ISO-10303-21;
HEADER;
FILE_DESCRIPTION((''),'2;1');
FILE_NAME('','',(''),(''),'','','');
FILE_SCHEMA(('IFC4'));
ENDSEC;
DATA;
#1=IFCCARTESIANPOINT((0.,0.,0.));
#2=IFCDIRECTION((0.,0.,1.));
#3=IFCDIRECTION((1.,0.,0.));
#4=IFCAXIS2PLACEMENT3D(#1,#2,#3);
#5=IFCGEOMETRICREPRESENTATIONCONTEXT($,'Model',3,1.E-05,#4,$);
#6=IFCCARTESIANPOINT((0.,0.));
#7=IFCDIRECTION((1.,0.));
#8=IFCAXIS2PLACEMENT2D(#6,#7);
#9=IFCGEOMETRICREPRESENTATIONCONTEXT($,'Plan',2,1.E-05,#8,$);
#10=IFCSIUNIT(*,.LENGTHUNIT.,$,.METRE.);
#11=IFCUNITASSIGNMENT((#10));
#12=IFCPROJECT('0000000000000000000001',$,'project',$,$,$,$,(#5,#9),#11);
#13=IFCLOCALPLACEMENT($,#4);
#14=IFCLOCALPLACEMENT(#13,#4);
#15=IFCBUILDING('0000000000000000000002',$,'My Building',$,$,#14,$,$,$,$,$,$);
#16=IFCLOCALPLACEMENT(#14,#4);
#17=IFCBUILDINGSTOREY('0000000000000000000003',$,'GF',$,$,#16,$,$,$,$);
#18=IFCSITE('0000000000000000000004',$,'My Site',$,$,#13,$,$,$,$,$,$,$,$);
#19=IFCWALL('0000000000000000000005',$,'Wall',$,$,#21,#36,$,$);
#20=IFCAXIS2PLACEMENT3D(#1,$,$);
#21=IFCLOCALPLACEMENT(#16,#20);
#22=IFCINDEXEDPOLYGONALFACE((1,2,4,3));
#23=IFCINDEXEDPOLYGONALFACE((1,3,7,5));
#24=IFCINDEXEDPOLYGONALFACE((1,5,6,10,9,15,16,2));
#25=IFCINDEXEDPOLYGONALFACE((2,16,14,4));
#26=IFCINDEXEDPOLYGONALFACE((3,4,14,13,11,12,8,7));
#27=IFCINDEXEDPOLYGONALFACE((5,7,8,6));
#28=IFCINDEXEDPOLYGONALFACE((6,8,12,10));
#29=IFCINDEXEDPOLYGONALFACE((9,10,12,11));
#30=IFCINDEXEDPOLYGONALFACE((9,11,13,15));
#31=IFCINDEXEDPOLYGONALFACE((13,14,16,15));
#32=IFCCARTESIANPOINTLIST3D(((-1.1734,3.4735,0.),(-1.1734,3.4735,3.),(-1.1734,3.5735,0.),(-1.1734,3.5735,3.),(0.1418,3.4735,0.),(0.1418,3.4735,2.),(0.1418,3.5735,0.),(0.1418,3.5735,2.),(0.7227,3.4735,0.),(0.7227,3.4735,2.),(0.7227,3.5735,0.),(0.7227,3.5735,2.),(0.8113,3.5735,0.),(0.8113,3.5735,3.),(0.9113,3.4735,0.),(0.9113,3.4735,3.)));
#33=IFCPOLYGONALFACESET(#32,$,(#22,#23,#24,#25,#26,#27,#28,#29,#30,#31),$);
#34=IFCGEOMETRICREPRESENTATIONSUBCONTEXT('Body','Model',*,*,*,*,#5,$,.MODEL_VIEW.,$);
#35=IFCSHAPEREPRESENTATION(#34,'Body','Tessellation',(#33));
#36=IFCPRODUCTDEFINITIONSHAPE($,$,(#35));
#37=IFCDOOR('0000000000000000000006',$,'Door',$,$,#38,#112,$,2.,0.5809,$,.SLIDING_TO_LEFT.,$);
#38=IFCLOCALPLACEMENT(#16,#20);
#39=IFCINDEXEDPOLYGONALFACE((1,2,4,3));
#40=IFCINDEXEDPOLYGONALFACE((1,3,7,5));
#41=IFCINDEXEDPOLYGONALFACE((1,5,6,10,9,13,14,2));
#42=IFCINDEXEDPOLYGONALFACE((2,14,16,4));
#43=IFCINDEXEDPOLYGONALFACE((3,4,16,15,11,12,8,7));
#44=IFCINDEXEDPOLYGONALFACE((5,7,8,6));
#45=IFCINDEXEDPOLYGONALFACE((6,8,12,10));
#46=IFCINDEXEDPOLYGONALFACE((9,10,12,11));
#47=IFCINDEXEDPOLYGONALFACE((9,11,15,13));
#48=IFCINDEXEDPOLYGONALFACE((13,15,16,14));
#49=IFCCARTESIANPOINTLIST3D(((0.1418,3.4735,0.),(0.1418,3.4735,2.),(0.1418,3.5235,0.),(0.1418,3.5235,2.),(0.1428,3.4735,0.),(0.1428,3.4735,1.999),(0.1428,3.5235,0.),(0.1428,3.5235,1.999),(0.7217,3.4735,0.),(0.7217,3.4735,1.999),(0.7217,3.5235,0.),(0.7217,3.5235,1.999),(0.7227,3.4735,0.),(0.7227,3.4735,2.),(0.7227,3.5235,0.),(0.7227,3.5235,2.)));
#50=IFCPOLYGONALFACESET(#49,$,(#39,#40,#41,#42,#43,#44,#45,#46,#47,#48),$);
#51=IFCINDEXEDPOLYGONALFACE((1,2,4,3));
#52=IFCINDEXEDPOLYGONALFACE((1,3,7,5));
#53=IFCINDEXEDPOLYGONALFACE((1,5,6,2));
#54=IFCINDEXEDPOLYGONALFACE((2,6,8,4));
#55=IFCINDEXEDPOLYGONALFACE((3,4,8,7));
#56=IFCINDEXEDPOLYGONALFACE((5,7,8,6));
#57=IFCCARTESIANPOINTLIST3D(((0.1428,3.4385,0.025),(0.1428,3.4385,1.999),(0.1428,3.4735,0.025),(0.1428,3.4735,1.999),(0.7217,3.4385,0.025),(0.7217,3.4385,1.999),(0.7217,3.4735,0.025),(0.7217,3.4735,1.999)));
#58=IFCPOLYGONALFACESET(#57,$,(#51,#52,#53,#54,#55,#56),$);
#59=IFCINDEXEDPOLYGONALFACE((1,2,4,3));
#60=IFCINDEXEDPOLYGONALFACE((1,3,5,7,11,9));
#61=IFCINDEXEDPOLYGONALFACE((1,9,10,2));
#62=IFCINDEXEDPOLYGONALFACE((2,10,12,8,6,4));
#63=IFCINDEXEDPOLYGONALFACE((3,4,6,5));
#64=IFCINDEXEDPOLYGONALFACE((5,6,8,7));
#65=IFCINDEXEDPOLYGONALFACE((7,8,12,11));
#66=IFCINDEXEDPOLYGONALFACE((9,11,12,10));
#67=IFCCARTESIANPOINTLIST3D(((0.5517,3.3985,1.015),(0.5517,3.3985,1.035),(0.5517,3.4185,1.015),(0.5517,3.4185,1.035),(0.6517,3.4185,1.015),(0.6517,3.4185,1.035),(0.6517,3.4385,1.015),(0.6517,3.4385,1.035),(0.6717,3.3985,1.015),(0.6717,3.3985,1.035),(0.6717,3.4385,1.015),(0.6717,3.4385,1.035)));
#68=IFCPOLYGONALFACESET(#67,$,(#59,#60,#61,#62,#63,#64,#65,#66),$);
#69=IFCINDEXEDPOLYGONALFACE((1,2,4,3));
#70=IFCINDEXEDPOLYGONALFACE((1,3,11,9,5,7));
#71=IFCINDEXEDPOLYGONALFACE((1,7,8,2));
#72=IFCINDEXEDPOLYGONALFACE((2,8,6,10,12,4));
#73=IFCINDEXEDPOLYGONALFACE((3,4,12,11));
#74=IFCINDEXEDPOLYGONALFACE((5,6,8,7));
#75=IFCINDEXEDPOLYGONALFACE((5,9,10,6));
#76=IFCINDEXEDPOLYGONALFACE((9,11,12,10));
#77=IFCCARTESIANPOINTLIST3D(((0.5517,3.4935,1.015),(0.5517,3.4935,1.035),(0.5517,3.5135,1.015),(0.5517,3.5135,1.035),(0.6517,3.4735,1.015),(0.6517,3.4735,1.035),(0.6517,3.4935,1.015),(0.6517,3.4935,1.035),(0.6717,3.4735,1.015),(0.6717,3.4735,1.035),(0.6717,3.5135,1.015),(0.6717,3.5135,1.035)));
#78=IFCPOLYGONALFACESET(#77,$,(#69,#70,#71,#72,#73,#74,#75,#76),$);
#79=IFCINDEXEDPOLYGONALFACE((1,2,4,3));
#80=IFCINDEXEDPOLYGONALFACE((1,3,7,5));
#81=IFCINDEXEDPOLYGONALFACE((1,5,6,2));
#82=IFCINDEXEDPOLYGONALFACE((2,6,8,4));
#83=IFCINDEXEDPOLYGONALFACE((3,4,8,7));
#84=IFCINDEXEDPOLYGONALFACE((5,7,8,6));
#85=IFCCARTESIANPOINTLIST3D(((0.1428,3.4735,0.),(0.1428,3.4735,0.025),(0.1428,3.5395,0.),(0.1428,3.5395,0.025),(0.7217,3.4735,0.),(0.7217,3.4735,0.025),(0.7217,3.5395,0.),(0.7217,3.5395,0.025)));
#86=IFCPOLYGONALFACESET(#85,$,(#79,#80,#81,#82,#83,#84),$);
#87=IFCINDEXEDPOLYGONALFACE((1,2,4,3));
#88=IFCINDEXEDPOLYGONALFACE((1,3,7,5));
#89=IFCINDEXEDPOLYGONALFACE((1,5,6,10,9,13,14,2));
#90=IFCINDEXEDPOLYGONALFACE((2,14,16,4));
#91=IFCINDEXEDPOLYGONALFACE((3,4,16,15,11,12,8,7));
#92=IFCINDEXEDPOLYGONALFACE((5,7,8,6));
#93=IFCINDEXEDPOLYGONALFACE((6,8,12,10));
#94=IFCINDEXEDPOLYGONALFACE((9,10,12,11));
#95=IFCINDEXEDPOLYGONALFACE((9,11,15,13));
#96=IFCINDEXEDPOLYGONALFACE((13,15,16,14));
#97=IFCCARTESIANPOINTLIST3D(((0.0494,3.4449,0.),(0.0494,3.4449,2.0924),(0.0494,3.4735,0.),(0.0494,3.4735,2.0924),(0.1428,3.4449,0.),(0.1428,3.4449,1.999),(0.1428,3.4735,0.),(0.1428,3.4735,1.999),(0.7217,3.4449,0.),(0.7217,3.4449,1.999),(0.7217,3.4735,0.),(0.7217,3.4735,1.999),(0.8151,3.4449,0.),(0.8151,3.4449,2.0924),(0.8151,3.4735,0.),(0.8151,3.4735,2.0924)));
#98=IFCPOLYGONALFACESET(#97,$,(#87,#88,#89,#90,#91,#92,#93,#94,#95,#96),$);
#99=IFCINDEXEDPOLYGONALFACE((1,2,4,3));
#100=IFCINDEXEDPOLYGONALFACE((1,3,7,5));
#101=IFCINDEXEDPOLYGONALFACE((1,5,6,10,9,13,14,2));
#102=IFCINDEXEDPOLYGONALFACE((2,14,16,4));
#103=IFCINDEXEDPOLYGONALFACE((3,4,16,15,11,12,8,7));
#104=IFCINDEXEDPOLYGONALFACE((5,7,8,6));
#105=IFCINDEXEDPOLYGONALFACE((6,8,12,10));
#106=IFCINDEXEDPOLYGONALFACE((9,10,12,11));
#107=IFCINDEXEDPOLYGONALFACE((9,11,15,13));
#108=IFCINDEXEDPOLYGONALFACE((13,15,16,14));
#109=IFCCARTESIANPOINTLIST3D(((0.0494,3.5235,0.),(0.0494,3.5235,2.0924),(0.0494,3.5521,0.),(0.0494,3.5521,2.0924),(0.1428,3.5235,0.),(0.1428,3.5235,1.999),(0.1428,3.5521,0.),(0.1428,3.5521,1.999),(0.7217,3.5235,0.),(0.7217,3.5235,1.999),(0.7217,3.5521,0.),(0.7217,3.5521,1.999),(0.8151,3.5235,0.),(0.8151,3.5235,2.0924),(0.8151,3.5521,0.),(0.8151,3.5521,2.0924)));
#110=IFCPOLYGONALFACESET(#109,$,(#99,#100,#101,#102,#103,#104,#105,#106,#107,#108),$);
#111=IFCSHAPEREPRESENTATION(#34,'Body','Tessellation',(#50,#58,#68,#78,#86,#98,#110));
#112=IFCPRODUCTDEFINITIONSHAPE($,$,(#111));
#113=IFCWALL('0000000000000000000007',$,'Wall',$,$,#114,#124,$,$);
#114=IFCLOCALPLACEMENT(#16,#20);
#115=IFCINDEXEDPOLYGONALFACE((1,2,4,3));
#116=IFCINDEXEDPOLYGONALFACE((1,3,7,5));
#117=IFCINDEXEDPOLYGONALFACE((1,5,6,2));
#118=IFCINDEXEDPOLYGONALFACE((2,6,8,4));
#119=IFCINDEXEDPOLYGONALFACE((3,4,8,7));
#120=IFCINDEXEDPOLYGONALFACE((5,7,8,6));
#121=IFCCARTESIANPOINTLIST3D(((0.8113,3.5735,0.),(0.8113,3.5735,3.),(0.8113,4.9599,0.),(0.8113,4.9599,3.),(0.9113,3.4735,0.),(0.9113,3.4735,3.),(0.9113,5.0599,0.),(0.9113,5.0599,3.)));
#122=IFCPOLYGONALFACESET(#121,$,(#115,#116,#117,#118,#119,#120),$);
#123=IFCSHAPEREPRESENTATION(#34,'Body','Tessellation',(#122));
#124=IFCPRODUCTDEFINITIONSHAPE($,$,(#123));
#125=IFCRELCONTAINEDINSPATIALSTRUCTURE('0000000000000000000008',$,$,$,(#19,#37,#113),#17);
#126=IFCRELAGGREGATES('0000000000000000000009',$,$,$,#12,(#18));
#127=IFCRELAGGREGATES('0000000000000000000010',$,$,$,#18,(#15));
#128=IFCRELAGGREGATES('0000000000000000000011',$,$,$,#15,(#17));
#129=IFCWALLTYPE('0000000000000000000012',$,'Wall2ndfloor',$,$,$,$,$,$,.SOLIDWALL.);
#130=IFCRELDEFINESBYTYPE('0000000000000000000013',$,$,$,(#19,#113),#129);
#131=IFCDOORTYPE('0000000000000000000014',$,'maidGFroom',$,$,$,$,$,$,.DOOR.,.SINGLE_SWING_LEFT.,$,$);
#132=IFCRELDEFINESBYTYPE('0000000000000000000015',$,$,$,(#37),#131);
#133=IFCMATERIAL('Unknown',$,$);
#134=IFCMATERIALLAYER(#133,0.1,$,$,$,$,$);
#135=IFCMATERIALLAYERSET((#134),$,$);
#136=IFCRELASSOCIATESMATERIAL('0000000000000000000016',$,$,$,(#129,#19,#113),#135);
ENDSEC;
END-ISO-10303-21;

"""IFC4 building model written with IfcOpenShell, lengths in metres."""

from ifc_helpers import new_model, entity, si_unit, frame, origin_with_axes, origin_2d_with_axis, place, context, subcontext, project, spatial, line, indexed_curve, outline, extrude, shape, source, transform, mapped, material, layer, layer_set, layer_usage, type_object, type_shapes, element, fill, save


model = new_model("IFC4")

# Units and contexts
model_context = context("Model", 3, precision=1e-05, world=origin_with_axes())
plan_context = context("Plan", 2, precision=1e-05, world=origin_2d_with_axis())
body_context_1 = subcontext(model_context, "Body", "Model", "MODEL_VIEW")
body_context_2 = subcontext(plan_context, "Body", "Plan", "PLAN_VIEW")
ifc_project = project(units=[si_unit("LENGTHUNIT", "METRE")], contexts=[model_context, plan_context])

# Site, building, storey
site_placement = place(None, origin_with_axes())
site = spatial("IfcSite", under=ifc_project, at=site_placement, Name="My Site")
building_placement = place(site_placement, origin_with_axes())
building = spatial("IfcBuilding", under=site, at=building_placement, Name="My Building")
storey_placement = place(building_placement, origin_with_axes())
storey = spatial("IfcBuildingStorey", under=building, at=storey_placement, Name="GF")

# Shared definitions
ifc_material = material(Name="Unknown")

# Shared definitions
ifc_layer = layer(ifc_material, 0.1)
ifc_layer_set = layer_set([ifc_layer])
wall_type = type_object("IfcWallType", Name="Wall2ndfloor", PredefinedType="SOLIDWALL", material=ifc_layer_set)

# Wall, opening, door
ifc_layer_usage_1 = layer_usage(ifc_layer_set, "AXIS2", "POSITIVE", 0.0)
wall_1_placement = place(storey_placement, frame((0.9113, 3.5735, 0.0), z_axis=(0.0, 0.0, 1.0), x_axis=(-1.0, 0.0, 0.0)))
wall_1 = element("IfcWall", 1, at=wall_1_placement, inside=storey, type_object=wall_type, material=ifc_layer_usage_1, Name="Wall", context=body_context_1, shape_type="SweptSolid", body=[
    extrude(outline(indexed_curve([(0.1, 0.0), (0.0, 0.1), (2.0847, 0.1), (2.0847, 0.0)], segments=[line(1, 2, 3, 4, 1)])), origin_with_axes(), (0.0, 0.0, 1.0), 3.0),
])
shared_shape_1 = source(origin_with_axes(), body_context_1, "Body", "SweptSolid", [
    extrude(outline(indexed_curve([(0.0, 0.0), (0.5809, 0.0), (0.5809, 2.0), (0.0, 2.0)], segments=[line(1, 2, 3, 4, 1)])), frame((0.0, -0.6, 0.0), z_axis=(0.0, -1.0, 0.0), x_axis=(1.0, 0.0, 0.0)), (0.0, 0.0, -1.0), 1.2),
])
opening_1_placement = place(wall_1_placement, frame((0.7695, 0.1, 0.0), z_axis=(0.0, 0.0, 1.0), x_axis=(-1.0, 0.0, 0.0)))
opening_1 = element("IfcOpeningElement", 2, at=opening_1_placement, cuts=wall_1, PredefinedType="OPENING", context=body_context_1, shape_type="MappedRepresentation", body=[
    mapped(shared_shape_1, transform((0.0, 0.0, 0.0), x_axis=(1.0, 0.0, 0.0), y_axis=(0.0, 1.0, 0.0), z_axis=(0.0, 0.0, 1.0), scale=1.0)),
])
door_type_1 = type_object("IfcDoorType", Name="maidGFroom", OperationType="SINGLE_SWING_LEFT", PredefinedType="DOOR")
shared_shape_2 = source(origin_with_axes(), body_context_1, "Body", "SweptSolid", [
    extrude(outline(indexed_curve([(0.0, 0.0), (0.0, 2.0), (0.5809, 2.0), (0.5809, 0.0), (0.5799, 0.0), (0.5799, 1.999), (0.001, 1.999), (0.001, 0.0)], segments=[line(1, 2, 3, 4, 5, 6, 7, 8, 1)])), frame((0.0, 0.0, 0.0), z_axis=(0.0, -1.0, 0.0), x_axis=(1.0, 0.0, 0.0)), (0.0, 0.0, -1.0), 0.05),
    extrude(outline(indexed_curve([(0.0, 0.0), (0.5789, 0.0), (0.5789, 0.035), (0.0, 0.035)], segments=[line(1, 2, 3, 4, 1)])), frame((0.001, -0.035, 0.025), z_axis=(0.0, 0.0, 1.0), x_axis=(1.0, 0.0, 0.0)), (0.0, 0.0, 1.0), 1.974),
    extrude(outline(indexed_curve([(0.0, 0.0), (0.0, -0.04), (-0.12, -0.04), (-0.12, -0.02), (-0.02, -0.02), (-0.02, 0.0)], segments=[line(1, 2, 3, 4, 5, 6, 1)])), frame((0.5299, -0.035, 1.015), z_axis=(0.0, 0.0, 1.0), x_axis=(1.0, 0.0, 0.0)), (0.0, 0.0, 1.0), 0.02),
    extrude(outline(indexed_curve([(0.0, 0.0), (0.0, 0.04), (-0.12, 0.04), (-0.12, 0.02), (-0.02, 0.02), (-0.02, 0.0)], segments=[line(1, 2, 3, 4, 5, 6, 1)])), frame((0.5299, 0.0, 1.015), z_axis=(0.0, 0.0, 1.0), x_axis=(1.0, 0.0, 0.0)), (0.0, 0.0, 1.0), 0.02),
    extrude(outline(indexed_curve([(0.0, 0.0), (0.5789, 0.0), (0.5789, 0.066), (0.0, 0.066)], segments=[line(1, 2, 3, 4, 1)])), frame((0.001, 0.0, 0.0), z_axis=(0.0, 0.0, 1.0), x_axis=(1.0, 0.0, 0.0)), (0.0, 0.0, 1.0), 0.025),
    extrude(outline(indexed_curve([(0.0, 0.0), (0.0, 2.0924), (0.7656, 2.0924), (0.7656, 0.0), (0.6723, 0.0), (0.6723, 1.999), (0.0934, 1.999), (0.0934, 0.0)], segments=[line(1, 2, 3, 4, 5, 6, 7, 8, 1)])), frame((-0.0924, -0.0286, 0.0), z_axis=(0.0, -1.0, 0.0), x_axis=(1.0, 0.0, 0.0)), (0.0, 0.0, -1.0), 0.0286),
    extrude(outline(indexed_curve([(0.0, 0.0), (0.0, 2.0924), (0.7656, 2.0924), (0.7656, 0.0), (0.6723, 0.0), (0.6723, 1.999), (0.0934, 1.999), (0.0934, 0.0)], segments=[line(1, 2, 3, 4, 5, 6, 7, 8, 1)])), frame((-0.0924, 0.05, 0.0), z_axis=(0.0, -1.0, 0.0), x_axis=(1.0, 0.0, 0.0)), (0.0, 0.0, -1.0), 0.0286),
])
shared_shape_3 = source(origin_with_axes(), body_context_2, "Body", "Curve2D", [
    entity("IfcIndexedPolyCurve", entity("IfcCartesianPointList2D", [[0.0, 0.0], [0.001, 0.0], [0.001, 0.05], [0.0, 0.05]]), [entity("IfcLineIndex", [1, 2, 3, 4, 1])]),
    entity("IfcIndexedPolyCurve", entity("IfcCartesianPointList2D", [[0.5809, 0.0], [0.5799, 0.0], [0.5799, 0.05], [0.5809, 0.05]]), [entity("IfcLineIndex", [1, 2, 3, 4, 1])]),
    entity("IfcIndexedPolyCurve", entity("IfcCartesianPointList2D", [[-0.2884, -0.035], [0.2904, -0.035], [0.2904, 0.0], [-0.2884, 0.0]]), [entity("IfcLineIndex", [1, 2, 3, 4, 1])]),
])
type_shapes(door_type_1, [shared_shape_2, shared_shape_3])
door_1_placement = place(opening_1_placement, frame((0.0, 0.0, 0.0), z_axis=(0.0, 0.0, 1.0), x_axis=(1.0, 0.0, 0.0)))
door_1 = element("IfcDoor", 3, at=door_1_placement, inside=storey, type_object=door_type_1, Name="Door", OperationType="SLIDING_TO_LEFT", OverallHeight=2.0, OverallWidth=0.5809, shapes=[
    shape(body_context_1, "Body", "MappedRepresentation", [mapped(shared_shape_2, transform((0.0, 0.0, 0.0), x_axis=(1.0, 0.0, 0.0), y_axis=(0.0, 1.0, 0.0), z_axis=(0.0, 0.0, 1.0), scale=1.0))]),
    shape(body_context_2, "Body", "MappedRepresentation", [mapped(shared_shape_3, transform((0.0, 0.0, 0.0), x_axis=(1.0, 0.0, 0.0), y_axis=(0.0, 1.0, 0.0), z_axis=(0.0, 0.0, 1.0), scale=1.0))]),
])
fill(opening_1, door_1)

# Wall
ifc_layer_usage_2 = layer_usage(ifc_layer_set, "AXIS2", "POSITIVE", 0.0)
wall_2_placement = place(storey_placement, frame((0.9113, 3.5735, 0.0), z_axis=(0.0, 0.0, 1.0), x_axis=(0.0, 1.0, 0.0)))
element("IfcWall", 4, at=wall_2_placement, inside=storey, type_object=wall_type, material=ifc_layer_usage_2, Name="Wall", context=body_context_1, shape_type="SweptSolid", body=[
    extrude(outline(indexed_curve([(-0.1, 0.0), (0.0, 0.1), (1.3864, 0.1), (1.4864, 0.0)], segments=[line(1, 2, 3, 4, 1)])), origin_with_axes(), (0.0, 0.0, 1.0), 3.0),
])

save(model, "model.ifc")
